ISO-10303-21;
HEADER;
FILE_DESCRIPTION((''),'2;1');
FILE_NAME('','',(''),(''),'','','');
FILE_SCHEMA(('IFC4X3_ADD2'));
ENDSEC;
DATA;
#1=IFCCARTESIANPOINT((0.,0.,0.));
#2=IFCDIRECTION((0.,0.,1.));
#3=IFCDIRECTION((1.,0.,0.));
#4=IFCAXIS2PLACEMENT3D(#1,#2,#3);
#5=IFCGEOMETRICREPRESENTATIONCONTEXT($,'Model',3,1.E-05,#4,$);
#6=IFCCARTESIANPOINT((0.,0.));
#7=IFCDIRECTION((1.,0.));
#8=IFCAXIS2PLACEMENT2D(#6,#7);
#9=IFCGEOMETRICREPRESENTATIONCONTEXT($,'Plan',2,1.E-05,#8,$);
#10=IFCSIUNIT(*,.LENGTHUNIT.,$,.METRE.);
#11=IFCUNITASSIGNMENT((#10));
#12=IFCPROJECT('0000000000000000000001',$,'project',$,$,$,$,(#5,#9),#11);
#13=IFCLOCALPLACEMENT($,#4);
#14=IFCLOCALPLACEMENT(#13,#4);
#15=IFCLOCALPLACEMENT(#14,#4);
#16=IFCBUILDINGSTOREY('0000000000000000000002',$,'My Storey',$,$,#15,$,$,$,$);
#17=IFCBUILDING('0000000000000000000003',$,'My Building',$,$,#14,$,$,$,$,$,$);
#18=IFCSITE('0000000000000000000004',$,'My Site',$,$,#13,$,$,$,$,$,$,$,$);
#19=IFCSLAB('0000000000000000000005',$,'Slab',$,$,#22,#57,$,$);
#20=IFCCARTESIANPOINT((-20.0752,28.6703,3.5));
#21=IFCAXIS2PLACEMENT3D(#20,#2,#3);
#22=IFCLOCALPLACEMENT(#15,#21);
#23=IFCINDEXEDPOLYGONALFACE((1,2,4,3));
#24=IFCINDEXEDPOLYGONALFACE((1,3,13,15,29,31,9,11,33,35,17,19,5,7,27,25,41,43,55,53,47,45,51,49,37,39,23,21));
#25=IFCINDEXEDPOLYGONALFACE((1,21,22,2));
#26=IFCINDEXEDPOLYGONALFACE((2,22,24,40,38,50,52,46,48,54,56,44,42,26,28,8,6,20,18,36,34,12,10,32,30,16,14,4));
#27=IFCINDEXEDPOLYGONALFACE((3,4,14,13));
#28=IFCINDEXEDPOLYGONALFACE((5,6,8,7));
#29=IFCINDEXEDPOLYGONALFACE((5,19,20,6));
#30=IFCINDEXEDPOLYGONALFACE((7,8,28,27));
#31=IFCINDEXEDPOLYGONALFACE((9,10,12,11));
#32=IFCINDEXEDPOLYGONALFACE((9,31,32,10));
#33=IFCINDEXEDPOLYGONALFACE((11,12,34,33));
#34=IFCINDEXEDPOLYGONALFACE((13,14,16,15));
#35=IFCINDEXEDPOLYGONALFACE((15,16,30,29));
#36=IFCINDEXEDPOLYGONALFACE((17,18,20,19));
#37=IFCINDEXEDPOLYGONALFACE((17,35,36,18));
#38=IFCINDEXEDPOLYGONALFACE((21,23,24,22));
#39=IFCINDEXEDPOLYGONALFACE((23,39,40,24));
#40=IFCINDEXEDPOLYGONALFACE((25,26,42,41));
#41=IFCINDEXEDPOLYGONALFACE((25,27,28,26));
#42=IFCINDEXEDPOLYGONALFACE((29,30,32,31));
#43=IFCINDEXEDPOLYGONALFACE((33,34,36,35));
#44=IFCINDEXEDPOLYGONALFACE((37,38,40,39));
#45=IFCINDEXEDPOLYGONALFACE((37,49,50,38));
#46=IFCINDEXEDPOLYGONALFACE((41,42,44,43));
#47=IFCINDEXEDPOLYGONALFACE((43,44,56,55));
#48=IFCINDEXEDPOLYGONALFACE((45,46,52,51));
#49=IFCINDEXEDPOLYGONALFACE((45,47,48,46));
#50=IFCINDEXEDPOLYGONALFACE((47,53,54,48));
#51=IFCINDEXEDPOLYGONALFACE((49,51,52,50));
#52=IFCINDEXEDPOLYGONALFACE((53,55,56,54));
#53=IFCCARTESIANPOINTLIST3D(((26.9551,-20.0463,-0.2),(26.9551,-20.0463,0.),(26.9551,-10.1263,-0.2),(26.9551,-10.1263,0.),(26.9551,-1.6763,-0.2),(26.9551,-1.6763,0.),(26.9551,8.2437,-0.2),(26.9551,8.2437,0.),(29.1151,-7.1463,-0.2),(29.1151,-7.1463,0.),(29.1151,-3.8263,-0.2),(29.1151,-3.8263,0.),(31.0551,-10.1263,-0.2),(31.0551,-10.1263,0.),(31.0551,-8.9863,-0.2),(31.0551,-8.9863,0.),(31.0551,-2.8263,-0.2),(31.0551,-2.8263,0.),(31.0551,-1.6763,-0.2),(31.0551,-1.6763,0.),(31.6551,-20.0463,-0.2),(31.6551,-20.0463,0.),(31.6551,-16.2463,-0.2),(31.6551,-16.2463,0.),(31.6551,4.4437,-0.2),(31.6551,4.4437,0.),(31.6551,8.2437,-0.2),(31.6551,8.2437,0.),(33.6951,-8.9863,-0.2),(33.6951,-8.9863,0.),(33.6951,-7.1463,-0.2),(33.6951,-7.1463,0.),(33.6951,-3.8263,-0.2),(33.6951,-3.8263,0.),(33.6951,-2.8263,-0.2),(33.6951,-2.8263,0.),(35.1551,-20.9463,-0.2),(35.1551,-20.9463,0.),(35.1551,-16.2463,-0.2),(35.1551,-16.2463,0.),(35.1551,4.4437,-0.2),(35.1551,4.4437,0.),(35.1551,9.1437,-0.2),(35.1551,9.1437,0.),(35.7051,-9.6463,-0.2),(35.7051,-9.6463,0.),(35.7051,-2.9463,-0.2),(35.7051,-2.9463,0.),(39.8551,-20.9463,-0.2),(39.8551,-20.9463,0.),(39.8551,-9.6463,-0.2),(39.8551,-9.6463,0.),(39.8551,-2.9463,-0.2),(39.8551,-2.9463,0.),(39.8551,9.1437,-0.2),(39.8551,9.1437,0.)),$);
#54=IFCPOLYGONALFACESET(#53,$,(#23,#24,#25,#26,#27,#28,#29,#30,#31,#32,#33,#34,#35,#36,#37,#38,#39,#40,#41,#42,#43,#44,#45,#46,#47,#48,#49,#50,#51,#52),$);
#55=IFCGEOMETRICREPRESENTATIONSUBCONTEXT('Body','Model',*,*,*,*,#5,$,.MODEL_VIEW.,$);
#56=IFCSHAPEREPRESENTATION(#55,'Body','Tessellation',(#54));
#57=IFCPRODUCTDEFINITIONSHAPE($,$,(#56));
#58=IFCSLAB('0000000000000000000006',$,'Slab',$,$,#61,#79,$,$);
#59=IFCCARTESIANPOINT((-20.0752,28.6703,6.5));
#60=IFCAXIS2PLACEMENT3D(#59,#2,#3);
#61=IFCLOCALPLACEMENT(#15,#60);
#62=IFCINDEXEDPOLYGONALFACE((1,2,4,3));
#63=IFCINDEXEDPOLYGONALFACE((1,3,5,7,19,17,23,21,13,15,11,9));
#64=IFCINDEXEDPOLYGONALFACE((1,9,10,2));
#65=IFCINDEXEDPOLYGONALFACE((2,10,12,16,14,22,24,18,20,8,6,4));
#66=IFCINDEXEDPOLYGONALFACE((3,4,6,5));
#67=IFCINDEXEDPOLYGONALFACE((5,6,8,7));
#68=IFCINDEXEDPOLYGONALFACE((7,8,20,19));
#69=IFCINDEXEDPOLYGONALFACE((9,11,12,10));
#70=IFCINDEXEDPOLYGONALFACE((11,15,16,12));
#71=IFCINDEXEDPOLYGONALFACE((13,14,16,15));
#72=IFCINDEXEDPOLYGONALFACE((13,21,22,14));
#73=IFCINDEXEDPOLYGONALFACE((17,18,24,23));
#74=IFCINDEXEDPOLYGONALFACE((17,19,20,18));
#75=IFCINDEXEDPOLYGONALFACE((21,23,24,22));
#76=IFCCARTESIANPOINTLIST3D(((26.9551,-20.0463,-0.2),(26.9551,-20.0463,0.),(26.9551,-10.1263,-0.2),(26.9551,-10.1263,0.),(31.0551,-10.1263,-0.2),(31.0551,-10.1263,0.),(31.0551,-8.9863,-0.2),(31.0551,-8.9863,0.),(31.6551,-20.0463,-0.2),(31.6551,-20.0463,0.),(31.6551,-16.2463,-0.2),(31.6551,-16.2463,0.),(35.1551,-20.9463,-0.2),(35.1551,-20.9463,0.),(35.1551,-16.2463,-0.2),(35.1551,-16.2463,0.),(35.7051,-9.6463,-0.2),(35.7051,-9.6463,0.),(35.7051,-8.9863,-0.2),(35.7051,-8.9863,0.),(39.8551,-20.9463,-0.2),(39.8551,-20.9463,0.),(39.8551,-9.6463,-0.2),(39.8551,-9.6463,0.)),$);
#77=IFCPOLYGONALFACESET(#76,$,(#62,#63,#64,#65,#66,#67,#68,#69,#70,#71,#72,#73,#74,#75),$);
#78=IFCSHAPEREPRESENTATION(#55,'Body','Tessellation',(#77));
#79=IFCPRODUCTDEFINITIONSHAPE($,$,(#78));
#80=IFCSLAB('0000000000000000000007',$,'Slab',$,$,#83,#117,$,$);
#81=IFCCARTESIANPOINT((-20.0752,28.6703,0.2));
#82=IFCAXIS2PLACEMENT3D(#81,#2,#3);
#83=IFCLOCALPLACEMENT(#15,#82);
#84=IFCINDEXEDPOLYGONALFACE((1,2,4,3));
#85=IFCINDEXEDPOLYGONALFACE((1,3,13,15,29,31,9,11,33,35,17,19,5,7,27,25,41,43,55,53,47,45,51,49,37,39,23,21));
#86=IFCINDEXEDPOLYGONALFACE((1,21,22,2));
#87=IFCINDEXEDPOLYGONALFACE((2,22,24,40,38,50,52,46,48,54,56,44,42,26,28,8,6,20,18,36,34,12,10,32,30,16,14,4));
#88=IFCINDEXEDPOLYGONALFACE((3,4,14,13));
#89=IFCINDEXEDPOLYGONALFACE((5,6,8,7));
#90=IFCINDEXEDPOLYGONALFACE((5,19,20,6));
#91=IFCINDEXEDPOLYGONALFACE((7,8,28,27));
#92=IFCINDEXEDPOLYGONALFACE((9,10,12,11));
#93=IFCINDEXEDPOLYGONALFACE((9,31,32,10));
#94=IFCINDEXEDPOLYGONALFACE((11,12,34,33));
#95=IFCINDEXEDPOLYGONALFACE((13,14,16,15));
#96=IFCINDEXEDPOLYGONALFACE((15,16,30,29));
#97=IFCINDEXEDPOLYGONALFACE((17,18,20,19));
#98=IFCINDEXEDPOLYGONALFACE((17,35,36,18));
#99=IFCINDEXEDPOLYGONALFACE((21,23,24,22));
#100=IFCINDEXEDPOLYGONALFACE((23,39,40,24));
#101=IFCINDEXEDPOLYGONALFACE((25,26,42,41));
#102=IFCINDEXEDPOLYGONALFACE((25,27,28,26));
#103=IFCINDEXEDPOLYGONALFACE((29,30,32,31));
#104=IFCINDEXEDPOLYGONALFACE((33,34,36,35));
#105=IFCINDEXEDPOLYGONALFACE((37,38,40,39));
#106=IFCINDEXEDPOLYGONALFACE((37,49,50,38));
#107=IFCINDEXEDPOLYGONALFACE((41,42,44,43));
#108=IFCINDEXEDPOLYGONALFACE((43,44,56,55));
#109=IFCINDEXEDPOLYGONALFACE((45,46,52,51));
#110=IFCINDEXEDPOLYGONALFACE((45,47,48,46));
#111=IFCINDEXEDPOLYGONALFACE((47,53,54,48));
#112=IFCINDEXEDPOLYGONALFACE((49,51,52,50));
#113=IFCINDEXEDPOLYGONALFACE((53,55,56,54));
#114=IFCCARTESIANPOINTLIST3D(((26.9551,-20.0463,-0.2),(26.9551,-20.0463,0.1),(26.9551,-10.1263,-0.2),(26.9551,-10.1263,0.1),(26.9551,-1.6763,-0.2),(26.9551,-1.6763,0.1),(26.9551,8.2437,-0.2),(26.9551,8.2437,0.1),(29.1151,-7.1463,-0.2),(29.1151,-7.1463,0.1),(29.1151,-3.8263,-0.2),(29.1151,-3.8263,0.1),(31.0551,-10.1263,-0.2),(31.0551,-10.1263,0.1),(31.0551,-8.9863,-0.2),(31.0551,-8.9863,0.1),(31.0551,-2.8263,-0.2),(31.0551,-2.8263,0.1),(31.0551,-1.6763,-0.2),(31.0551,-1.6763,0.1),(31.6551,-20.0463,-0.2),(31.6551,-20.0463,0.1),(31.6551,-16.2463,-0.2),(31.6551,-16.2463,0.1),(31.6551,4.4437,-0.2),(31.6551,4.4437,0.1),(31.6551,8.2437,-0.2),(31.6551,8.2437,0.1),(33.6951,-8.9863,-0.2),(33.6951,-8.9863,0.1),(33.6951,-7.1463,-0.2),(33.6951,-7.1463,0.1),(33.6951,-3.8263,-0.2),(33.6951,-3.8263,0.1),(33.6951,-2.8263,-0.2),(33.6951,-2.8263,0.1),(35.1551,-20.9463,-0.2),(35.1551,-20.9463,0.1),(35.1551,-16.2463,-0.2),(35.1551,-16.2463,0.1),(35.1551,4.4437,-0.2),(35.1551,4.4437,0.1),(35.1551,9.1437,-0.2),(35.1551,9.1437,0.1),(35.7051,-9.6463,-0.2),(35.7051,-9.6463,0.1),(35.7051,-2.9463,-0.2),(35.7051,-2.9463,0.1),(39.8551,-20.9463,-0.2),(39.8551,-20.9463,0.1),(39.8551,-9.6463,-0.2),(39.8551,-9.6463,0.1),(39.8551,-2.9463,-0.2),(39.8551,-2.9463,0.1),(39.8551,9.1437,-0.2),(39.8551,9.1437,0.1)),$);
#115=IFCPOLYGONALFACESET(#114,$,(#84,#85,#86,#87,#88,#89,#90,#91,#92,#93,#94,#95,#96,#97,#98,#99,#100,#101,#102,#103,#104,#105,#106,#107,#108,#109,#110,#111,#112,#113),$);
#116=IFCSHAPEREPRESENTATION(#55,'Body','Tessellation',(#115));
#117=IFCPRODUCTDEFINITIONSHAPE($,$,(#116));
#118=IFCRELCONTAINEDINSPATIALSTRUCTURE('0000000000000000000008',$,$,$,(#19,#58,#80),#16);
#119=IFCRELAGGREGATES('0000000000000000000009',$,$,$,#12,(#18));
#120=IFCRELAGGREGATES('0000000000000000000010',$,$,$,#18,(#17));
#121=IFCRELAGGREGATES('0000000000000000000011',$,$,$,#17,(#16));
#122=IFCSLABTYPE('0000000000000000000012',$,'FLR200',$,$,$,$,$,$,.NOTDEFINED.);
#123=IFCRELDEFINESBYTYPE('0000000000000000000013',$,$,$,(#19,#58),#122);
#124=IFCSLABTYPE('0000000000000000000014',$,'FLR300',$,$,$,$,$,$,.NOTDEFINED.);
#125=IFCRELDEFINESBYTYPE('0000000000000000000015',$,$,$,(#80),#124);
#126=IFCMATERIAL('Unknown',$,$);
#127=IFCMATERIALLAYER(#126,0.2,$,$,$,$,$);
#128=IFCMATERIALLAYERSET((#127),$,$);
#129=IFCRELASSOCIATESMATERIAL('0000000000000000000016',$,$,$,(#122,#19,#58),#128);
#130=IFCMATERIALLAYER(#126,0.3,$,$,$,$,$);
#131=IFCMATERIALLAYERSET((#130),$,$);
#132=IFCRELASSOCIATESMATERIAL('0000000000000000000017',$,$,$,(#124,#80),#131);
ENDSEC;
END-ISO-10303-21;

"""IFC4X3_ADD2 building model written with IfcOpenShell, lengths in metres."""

from ifc_helpers import new_model, si_unit, frame, origin_with_axes, origin_2d_with_axis, place, context, subcontext, project, spatial, indexed_curve, outline, extrude, material, layer, layer_set, layer_usage, type_object, element, save


model = new_model("IFC4X3_ADD2")

# Units and contexts
model_context = context("Model", 3, precision=1e-05, world=origin_with_axes())
plan_context = context("Plan", 2, precision=1e-05, world=origin_2d_with_axis())
body_context = subcontext(model_context, "Body", "Model", "MODEL_VIEW")
ifc_project = project(units=[si_unit("LENGTHUNIT", "METRE")], contexts=[model_context, plan_context])

# Site, building, storey
site_placement = place(None, origin_with_axes())
site = spatial("IfcSite", under=ifc_project, at=site_placement, Name="My Site")
building_placement = place(site_placement, origin_with_axes())
building = spatial("IfcBuilding", under=site, at=building_placement, Name="My Building")
storey_placement = place(building_placement, origin_with_axes())
storey = spatial("IfcBuildingStorey", under=building, at=storey_placement, Name="My Storey")

# Slabs
ifc_material = material(Name="Unknown")
ifc_layer_1 = layer(ifc_material, 0.2)
ifc_layer_set_1 = layer_set([ifc_layer_1])
ifc_layer_usage_1 = layer_usage(ifc_layer_set_1, "AXIS3", "POSITIVE", -0.2)
slab_type_1 = type_object("IfcSlabType", Name="FLR200", PredefinedType="NOTDEFINED", material=ifc_layer_set_1)
slab_1_placement = place(storey_placement, frame((-20.0752, 28.6703, 3.5), z_axis=(0.0, 0.0, 1.0), x_axis=(1.0, 0.0, 0.0)))
element("IfcSlab", 1, at=slab_1_placement, inside=storey, type_object=slab_type_1, material=ifc_layer_usage_1, Name="Slab", context=body_context, shape_type="SweptSolid", body=[
    extrude(outline(indexed_curve([(35.1551, -20.9463), (39.8551, -20.9463), (39.8551, -9.6463), (35.7051, -9.6463), (35.7051, -2.9463), (39.8551, -2.9463), (39.8551, 9.1437), (35.1551, 9.1437), (35.1551, 4.4437), (31.6551, 4.4437), (31.6551, 8.2437), (26.9551, 8.2437), (26.9551, -1.6763), (31.0551, -1.6763), (31.0551, -2.8263), (33.6951, -2.8263), (33.6951, -3.8263), (29.1151, -3.8263), (29.1151, -7.1463), (33.6951, -7.1463), (33.6951, -8.9863), (31.0551, -8.9863), (31.0551, -10.1263), (26.9551, -10.1263), (26.9551, -20.0463), (31.6551, -20.0463), (31.6551, -16.2463), (35.1551, -16.2463), (35.1551, -20.9463)])), frame((0.0, 0.0, -0.2), z_axis=(0.0, 0.0, 1.0), x_axis=(1.0, 0.0, 0.0)), (0.0, 0.0, 1.0), 0.2),
])
ifc_layer_usage_2 = layer_usage(ifc_layer_set_1, "AXIS3", "POSITIVE", -0.2)
slab_2_placement = place(storey_placement, frame((-20.0752, 28.6703, 6.5), z_axis=(0.0, 0.0, 1.0), x_axis=(1.0, 0.0, 0.0)))
element("IfcSlab", 2, at=slab_2_placement, inside=storey, type_object=slab_type_1, material=ifc_layer_usage_2, Name="Slab", context=body_context, shape_type="SweptSolid", body=[
    extrude(outline(indexed_curve([(35.1551, -16.2463), (31.6551, -16.2463), (31.6551, -20.0463), (26.9551, -20.0463), (26.9551, -10.1263), (31.0551, -10.1263), (31.0551, -8.9863), (35.7051, -8.9863), (35.7051, -9.6463), (39.8551, -9.6463), (39.8551, -20.9463), (35.1551, -20.9463), (35.1551, -16.2463)])), frame((0.0, 0.0, -0.2), z_axis=(0.0, 0.0, 1.0), x_axis=(1.0, 0.0, 0.0)), (0.0, 0.0, 1.0), 0.2),
])
ifc_layer_2 = layer(ifc_material, 0.3)
ifc_layer_set_2 = layer_set([ifc_layer_2])
ifc_layer_usage_3 = layer_usage(ifc_layer_set_2, "AXIS3", "POSITIVE", -0.2)
slab_type_2 = type_object("IfcSlabType", Name="FLR300", PredefinedType="NOTDEFINED", material=ifc_layer_set_2)
slab_3_placement = place(storey_placement, frame((-20.0752, 28.6703, 0.2), z_axis=(0.0, 0.0, 1.0), x_axis=(1.0, 0.0, 0.0)))
element("IfcSlab", 3, at=slab_3_placement, inside=storey, type_object=slab_type_2, material=ifc_layer_usage_3, Name="Slab", context=body_context, shape_type="SweptSolid", body=[
    extrude(outline(indexed_curve([(35.1551, -20.9463), (39.8551, -20.9463), (39.8551, -9.6463), (35.7051, -9.6463), (35.7051, -2.9463), (39.8551, -2.9463), (39.8551, 9.1437), (35.1551, 9.1437), (35.1551, 4.4437), (31.6551, 4.4437), (31.6551, 8.2437), (26.9551, 8.2437), (26.9551, -1.6763), (31.0551, -1.6763), (31.0551, -2.8263), (33.6951, -2.8263), (33.6951, -3.8263), (29.1151, -3.8263), (29.1151, -7.1463), (33.6951, -7.1463), (33.6951, -8.9863), (31.0551, -8.9863), (31.0551, -10.1263), (26.9551, -10.1263), (26.9551, -20.0463), (31.6551, -20.0463), (31.6551, -16.2463), (35.1551, -16.2463), (35.1551, -20.9463)])), frame((0.0, 0.0, -0.2), z_axis=(0.0, 0.0, 1.0), x_axis=(1.0, 0.0, 0.0)), (0.0, 0.0, 1.0), 0.3),
])

save(model, "model.ifc")
